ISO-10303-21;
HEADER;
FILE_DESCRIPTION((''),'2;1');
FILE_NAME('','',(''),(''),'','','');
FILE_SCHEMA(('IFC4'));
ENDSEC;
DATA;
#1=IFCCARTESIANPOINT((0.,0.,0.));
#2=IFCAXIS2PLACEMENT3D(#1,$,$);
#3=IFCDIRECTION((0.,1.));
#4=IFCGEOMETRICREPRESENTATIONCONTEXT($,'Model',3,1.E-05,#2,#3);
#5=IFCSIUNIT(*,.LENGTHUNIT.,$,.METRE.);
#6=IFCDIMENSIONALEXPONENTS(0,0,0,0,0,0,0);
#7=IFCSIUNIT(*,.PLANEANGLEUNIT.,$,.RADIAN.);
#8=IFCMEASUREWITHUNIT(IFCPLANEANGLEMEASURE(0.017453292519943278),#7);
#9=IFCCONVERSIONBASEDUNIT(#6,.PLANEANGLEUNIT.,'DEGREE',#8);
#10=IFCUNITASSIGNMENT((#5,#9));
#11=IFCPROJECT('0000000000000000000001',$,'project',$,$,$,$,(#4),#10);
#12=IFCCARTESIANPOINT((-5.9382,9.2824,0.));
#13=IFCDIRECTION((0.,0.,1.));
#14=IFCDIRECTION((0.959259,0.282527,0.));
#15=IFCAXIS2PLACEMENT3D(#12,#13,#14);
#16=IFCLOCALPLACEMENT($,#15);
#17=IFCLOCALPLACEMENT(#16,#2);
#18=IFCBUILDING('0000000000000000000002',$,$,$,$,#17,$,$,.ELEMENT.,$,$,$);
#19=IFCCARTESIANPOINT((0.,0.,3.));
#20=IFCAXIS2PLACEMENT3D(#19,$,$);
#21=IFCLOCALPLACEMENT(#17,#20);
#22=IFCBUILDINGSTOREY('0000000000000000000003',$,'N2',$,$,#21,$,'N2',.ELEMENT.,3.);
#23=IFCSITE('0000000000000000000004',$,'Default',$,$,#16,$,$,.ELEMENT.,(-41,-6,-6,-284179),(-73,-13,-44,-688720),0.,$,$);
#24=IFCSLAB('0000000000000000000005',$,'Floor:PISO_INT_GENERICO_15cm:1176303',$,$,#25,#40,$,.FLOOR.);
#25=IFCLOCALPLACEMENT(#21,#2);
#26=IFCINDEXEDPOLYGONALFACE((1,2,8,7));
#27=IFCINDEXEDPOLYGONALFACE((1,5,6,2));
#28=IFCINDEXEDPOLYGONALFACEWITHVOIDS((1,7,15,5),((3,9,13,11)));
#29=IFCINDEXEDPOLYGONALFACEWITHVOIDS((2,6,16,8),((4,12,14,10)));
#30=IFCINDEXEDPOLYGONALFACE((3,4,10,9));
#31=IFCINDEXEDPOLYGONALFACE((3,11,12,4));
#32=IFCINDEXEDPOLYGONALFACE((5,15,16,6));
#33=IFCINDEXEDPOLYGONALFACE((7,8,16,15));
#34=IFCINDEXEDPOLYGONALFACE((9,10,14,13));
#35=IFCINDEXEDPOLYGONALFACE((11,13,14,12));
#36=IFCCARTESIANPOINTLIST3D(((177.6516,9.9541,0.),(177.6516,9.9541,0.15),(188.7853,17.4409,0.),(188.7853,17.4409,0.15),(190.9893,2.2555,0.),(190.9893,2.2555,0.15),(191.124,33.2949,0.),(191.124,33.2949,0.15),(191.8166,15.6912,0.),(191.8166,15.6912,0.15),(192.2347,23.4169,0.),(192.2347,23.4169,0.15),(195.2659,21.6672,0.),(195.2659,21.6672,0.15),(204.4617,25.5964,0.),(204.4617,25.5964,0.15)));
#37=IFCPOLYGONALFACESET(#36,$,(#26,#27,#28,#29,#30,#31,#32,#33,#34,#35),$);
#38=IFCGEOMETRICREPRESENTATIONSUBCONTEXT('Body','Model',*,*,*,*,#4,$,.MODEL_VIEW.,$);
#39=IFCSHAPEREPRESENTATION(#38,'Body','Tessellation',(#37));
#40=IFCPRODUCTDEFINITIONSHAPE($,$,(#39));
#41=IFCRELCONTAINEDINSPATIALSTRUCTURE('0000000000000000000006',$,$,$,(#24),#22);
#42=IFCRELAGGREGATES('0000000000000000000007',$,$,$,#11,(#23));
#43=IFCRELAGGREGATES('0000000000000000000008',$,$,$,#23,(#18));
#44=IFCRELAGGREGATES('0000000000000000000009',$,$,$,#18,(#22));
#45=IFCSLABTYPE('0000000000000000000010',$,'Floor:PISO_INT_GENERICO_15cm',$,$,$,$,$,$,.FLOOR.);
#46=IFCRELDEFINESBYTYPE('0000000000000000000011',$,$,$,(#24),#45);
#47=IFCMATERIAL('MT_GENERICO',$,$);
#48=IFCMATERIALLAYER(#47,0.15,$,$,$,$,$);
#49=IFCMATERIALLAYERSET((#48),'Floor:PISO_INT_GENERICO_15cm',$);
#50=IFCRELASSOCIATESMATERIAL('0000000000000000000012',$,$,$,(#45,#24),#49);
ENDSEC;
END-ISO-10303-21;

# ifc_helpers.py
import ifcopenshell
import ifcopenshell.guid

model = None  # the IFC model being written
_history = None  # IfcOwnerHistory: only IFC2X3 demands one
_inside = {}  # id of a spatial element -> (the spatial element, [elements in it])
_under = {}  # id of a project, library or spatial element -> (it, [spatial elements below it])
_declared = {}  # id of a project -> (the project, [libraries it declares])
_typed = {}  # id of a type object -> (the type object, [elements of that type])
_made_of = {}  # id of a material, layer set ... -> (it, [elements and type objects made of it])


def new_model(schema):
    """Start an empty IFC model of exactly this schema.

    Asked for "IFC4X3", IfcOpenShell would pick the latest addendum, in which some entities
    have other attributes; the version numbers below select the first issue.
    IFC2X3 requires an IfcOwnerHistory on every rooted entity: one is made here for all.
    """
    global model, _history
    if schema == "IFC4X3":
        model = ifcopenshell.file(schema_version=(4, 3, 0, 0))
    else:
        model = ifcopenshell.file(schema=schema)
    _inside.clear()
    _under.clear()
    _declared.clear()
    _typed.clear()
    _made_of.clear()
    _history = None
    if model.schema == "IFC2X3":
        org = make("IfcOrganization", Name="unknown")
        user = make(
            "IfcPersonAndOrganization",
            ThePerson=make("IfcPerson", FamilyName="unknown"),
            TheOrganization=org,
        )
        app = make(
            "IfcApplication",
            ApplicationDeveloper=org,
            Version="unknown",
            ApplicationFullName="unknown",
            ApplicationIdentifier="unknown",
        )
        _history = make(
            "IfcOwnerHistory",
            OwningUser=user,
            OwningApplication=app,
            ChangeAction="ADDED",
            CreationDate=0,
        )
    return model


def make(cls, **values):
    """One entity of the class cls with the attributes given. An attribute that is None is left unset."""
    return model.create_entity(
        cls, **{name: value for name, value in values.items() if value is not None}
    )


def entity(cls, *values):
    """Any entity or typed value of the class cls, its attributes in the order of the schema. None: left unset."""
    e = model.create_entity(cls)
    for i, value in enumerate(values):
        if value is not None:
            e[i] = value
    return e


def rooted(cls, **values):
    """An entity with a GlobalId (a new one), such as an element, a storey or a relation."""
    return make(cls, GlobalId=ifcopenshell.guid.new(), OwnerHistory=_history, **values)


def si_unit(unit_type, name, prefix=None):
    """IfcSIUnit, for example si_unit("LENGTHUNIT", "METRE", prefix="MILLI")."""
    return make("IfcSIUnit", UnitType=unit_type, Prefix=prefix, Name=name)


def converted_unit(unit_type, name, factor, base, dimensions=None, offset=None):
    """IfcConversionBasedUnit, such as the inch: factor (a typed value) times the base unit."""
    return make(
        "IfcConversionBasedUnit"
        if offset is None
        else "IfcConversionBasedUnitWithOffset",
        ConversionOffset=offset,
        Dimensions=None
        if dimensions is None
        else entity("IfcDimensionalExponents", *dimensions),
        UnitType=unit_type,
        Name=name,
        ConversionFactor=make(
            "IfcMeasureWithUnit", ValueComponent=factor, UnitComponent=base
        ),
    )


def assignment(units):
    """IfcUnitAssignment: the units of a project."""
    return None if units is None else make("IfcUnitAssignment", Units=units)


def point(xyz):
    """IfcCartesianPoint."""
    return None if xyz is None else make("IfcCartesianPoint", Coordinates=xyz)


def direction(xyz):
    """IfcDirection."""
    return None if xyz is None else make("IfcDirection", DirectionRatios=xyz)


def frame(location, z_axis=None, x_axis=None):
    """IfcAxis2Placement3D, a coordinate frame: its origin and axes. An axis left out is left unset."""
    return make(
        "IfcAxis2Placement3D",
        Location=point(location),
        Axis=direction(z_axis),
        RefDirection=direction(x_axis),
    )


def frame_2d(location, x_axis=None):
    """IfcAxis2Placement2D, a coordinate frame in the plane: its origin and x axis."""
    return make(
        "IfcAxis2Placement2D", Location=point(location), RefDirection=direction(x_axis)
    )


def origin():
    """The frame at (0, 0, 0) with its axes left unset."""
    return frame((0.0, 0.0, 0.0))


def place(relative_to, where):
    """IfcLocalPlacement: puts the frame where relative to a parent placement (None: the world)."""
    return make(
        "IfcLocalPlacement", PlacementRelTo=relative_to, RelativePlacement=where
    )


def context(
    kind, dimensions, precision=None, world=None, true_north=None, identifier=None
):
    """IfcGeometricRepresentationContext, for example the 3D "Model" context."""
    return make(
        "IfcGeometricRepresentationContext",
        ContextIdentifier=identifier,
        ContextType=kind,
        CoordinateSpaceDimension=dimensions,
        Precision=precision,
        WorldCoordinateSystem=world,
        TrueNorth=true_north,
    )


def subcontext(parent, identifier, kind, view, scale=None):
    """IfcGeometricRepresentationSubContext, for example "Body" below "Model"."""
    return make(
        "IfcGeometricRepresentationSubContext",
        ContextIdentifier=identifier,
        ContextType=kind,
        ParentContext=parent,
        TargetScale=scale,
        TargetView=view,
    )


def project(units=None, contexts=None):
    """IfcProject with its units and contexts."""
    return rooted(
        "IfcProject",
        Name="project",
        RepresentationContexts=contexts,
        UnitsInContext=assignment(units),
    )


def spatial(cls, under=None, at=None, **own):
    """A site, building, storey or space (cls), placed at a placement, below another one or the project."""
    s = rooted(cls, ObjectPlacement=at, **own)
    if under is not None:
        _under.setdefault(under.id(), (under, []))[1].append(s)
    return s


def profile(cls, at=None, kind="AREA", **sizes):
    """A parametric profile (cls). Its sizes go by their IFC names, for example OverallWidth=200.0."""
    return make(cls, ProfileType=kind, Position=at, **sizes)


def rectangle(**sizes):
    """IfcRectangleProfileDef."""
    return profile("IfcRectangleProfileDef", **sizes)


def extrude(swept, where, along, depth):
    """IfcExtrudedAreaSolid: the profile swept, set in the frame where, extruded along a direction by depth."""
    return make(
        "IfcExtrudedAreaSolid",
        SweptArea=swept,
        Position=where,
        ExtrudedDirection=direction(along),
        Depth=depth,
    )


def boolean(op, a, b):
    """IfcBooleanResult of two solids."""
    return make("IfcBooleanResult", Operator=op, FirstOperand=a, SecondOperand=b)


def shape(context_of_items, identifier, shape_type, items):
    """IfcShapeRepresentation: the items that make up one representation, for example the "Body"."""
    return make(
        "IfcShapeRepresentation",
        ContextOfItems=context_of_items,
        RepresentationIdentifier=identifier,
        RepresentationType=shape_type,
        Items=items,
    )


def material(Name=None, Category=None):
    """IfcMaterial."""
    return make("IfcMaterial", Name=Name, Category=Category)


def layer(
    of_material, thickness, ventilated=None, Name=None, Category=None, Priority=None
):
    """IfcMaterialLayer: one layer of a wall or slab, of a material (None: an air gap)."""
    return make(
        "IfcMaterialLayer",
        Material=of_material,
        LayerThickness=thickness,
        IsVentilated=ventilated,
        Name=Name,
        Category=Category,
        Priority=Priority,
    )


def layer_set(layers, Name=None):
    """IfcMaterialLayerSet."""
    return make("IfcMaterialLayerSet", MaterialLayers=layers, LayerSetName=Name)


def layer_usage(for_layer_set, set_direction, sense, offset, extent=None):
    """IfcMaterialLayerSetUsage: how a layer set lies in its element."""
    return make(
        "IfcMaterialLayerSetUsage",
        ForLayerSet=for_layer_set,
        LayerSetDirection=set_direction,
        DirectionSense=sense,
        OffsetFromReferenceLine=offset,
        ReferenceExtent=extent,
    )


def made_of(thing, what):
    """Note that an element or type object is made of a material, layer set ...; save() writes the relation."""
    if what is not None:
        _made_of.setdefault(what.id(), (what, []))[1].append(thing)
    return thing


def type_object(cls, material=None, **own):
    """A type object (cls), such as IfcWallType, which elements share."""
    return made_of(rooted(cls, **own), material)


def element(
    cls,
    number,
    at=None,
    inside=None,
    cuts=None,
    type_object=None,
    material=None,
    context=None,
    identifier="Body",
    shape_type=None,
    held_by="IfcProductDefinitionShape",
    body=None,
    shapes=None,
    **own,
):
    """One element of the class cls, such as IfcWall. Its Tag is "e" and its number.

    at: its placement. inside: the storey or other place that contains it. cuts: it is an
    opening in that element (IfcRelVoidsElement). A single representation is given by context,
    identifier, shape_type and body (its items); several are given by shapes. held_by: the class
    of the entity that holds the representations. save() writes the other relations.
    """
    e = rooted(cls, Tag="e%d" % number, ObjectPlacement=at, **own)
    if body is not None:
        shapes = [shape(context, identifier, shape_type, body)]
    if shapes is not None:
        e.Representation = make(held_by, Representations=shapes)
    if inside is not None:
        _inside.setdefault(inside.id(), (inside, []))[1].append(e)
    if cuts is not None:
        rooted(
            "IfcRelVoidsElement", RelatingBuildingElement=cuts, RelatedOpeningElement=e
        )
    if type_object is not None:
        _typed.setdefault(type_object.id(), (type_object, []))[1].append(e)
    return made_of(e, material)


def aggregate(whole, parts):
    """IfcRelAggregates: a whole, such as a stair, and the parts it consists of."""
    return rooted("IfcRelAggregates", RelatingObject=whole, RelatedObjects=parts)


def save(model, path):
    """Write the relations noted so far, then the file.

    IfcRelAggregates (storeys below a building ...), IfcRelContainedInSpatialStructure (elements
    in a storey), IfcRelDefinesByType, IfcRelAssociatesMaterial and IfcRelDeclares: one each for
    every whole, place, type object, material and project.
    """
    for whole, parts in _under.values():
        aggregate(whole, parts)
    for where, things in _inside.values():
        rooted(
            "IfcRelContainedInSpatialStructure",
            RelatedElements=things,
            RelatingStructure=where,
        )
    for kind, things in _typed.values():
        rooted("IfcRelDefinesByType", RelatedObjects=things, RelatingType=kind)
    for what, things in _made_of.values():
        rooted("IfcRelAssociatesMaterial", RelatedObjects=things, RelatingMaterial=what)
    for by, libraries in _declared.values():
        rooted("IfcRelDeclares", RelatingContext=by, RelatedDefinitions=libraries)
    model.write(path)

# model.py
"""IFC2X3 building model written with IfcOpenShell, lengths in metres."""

from ifc_helpers import new_model, entity, si_unit, converted_unit, direction, frame, frame_2d, origin, place, context, subcontext, project, spatial, rectangle, extrude, boolean, material, layer, layer_set, layer_usage, type_object, element, save


model = new_model("IFC2X3")

# Units and contexts
model_context = context("Model", 3, precision=1e-05, world=origin(), true_north=direction((0.0, 1.0)))
body_context = subcontext(model_context, "Body", "Model", "MODEL_VIEW")
ifc_project = project(units=[si_unit("LENGTHUNIT", "METRE"), converted_unit("PLANEANGLEUNIT", "DEGREE", entity("IfcPlaneAngleMeasure", 0.017453292519943278), si_unit("PLANEANGLEUNIT", "RADIAN"), dimensions=[0, 0, 0, 0, 0, 0, 0])], contexts=[model_context])

# Site, building, storey
site_placement = place(None, frame((-5.9382, 9.2824, 0.0), z_axis=(0.0, 0.0, 1.0), x_axis=(0.959259, 0.282527, 0.0)))
site = spatial("IfcSite", under=ifc_project, at=site_placement, Name="Default", CompositionType="ELEMENT", RefLatitude=(-41, -6, -6, -284179), RefLongitude=(-73, -13, -44, -688720), RefElevation=0.0)
building_placement = place(site_placement, origin())
building = spatial("IfcBuilding", under=site, at=building_placement, CompositionType="ELEMENT")
storey_placement = place(building_placement, frame((0.0, 0.0, 3.0)))
storey = spatial("IfcBuildingStorey", under=building, at=storey_placement, Name="N2", LongName="N2", CompositionType="ELEMENT", Elevation=3.0)

# Slab, opening
ifc_material = material(Name="MT_GENERICO")
ifc_layer = layer(ifc_material, 0.15)
ifc_layer_set = layer_set([ifc_layer], Name="Floor:PISO_INT_GENERICO_15cm")
ifc_layer_usage = layer_usage(ifc_layer_set, "AXIS3", "POSITIVE", 0.0)
slab_type = type_object("IfcSlabType", Name="Floor:PISO_INT_GENERICO_15cm", PredefinedType="FLOOR", material=ifc_layer_set)
slab_placement = place(storey_placement, origin())
slab = element("IfcSlab", 1, at=slab_placement, inside=storey, type_object=slab_type, material=ifc_layer_usage, Name="Floor:PISO_INT_GENERICO_15cm:1176303", PredefinedType="FLOOR", context=body_context, shape_type="CSG", body=[
    boolean("DIFFERENCE", extrude(rectangle(XDim=26.95, YDim=15.4, at=frame_2d((0.0, 0.0), x_axis=(1.0, 0.0))), frame((191.0566, 17.7752, 0.15), z_axis=(0.0, 0.0, -1.0), x_axis=(-0.499903, -0.866082, 0.0)), (0.0, 0.0, 1.0), 0.15), extrude(rectangle(XDim=6.9, YDim=3.5, at=frame_2d((0.0, 0.0), x_axis=(1.0, 0.0))), frame((192.0256, 19.5541, 0.0), z_axis=(0.0, 0.0, 1.0), x_axis=(0.499903, 0.866082, 0.0)), (0.0, 0.0, 1.0), 0.15)),
])
opening_placement = place(slab_placement, origin())
element("IfcOpeningElement", 2, at=opening_placement, cuts=slab, ObjectType="Opening", context=body_context, shape_type="SweptSolid", body=[
    extrude(rectangle(XDim=3.5, YDim=6.9, at=frame_2d((192.0256, 19.5541), x_axis=(0.866082, -0.499903))), frame((0.0, 0.0, 0.15)), (0.0, 0.0, -1.0), 0.15),
])

save(model, "model.ifc")
